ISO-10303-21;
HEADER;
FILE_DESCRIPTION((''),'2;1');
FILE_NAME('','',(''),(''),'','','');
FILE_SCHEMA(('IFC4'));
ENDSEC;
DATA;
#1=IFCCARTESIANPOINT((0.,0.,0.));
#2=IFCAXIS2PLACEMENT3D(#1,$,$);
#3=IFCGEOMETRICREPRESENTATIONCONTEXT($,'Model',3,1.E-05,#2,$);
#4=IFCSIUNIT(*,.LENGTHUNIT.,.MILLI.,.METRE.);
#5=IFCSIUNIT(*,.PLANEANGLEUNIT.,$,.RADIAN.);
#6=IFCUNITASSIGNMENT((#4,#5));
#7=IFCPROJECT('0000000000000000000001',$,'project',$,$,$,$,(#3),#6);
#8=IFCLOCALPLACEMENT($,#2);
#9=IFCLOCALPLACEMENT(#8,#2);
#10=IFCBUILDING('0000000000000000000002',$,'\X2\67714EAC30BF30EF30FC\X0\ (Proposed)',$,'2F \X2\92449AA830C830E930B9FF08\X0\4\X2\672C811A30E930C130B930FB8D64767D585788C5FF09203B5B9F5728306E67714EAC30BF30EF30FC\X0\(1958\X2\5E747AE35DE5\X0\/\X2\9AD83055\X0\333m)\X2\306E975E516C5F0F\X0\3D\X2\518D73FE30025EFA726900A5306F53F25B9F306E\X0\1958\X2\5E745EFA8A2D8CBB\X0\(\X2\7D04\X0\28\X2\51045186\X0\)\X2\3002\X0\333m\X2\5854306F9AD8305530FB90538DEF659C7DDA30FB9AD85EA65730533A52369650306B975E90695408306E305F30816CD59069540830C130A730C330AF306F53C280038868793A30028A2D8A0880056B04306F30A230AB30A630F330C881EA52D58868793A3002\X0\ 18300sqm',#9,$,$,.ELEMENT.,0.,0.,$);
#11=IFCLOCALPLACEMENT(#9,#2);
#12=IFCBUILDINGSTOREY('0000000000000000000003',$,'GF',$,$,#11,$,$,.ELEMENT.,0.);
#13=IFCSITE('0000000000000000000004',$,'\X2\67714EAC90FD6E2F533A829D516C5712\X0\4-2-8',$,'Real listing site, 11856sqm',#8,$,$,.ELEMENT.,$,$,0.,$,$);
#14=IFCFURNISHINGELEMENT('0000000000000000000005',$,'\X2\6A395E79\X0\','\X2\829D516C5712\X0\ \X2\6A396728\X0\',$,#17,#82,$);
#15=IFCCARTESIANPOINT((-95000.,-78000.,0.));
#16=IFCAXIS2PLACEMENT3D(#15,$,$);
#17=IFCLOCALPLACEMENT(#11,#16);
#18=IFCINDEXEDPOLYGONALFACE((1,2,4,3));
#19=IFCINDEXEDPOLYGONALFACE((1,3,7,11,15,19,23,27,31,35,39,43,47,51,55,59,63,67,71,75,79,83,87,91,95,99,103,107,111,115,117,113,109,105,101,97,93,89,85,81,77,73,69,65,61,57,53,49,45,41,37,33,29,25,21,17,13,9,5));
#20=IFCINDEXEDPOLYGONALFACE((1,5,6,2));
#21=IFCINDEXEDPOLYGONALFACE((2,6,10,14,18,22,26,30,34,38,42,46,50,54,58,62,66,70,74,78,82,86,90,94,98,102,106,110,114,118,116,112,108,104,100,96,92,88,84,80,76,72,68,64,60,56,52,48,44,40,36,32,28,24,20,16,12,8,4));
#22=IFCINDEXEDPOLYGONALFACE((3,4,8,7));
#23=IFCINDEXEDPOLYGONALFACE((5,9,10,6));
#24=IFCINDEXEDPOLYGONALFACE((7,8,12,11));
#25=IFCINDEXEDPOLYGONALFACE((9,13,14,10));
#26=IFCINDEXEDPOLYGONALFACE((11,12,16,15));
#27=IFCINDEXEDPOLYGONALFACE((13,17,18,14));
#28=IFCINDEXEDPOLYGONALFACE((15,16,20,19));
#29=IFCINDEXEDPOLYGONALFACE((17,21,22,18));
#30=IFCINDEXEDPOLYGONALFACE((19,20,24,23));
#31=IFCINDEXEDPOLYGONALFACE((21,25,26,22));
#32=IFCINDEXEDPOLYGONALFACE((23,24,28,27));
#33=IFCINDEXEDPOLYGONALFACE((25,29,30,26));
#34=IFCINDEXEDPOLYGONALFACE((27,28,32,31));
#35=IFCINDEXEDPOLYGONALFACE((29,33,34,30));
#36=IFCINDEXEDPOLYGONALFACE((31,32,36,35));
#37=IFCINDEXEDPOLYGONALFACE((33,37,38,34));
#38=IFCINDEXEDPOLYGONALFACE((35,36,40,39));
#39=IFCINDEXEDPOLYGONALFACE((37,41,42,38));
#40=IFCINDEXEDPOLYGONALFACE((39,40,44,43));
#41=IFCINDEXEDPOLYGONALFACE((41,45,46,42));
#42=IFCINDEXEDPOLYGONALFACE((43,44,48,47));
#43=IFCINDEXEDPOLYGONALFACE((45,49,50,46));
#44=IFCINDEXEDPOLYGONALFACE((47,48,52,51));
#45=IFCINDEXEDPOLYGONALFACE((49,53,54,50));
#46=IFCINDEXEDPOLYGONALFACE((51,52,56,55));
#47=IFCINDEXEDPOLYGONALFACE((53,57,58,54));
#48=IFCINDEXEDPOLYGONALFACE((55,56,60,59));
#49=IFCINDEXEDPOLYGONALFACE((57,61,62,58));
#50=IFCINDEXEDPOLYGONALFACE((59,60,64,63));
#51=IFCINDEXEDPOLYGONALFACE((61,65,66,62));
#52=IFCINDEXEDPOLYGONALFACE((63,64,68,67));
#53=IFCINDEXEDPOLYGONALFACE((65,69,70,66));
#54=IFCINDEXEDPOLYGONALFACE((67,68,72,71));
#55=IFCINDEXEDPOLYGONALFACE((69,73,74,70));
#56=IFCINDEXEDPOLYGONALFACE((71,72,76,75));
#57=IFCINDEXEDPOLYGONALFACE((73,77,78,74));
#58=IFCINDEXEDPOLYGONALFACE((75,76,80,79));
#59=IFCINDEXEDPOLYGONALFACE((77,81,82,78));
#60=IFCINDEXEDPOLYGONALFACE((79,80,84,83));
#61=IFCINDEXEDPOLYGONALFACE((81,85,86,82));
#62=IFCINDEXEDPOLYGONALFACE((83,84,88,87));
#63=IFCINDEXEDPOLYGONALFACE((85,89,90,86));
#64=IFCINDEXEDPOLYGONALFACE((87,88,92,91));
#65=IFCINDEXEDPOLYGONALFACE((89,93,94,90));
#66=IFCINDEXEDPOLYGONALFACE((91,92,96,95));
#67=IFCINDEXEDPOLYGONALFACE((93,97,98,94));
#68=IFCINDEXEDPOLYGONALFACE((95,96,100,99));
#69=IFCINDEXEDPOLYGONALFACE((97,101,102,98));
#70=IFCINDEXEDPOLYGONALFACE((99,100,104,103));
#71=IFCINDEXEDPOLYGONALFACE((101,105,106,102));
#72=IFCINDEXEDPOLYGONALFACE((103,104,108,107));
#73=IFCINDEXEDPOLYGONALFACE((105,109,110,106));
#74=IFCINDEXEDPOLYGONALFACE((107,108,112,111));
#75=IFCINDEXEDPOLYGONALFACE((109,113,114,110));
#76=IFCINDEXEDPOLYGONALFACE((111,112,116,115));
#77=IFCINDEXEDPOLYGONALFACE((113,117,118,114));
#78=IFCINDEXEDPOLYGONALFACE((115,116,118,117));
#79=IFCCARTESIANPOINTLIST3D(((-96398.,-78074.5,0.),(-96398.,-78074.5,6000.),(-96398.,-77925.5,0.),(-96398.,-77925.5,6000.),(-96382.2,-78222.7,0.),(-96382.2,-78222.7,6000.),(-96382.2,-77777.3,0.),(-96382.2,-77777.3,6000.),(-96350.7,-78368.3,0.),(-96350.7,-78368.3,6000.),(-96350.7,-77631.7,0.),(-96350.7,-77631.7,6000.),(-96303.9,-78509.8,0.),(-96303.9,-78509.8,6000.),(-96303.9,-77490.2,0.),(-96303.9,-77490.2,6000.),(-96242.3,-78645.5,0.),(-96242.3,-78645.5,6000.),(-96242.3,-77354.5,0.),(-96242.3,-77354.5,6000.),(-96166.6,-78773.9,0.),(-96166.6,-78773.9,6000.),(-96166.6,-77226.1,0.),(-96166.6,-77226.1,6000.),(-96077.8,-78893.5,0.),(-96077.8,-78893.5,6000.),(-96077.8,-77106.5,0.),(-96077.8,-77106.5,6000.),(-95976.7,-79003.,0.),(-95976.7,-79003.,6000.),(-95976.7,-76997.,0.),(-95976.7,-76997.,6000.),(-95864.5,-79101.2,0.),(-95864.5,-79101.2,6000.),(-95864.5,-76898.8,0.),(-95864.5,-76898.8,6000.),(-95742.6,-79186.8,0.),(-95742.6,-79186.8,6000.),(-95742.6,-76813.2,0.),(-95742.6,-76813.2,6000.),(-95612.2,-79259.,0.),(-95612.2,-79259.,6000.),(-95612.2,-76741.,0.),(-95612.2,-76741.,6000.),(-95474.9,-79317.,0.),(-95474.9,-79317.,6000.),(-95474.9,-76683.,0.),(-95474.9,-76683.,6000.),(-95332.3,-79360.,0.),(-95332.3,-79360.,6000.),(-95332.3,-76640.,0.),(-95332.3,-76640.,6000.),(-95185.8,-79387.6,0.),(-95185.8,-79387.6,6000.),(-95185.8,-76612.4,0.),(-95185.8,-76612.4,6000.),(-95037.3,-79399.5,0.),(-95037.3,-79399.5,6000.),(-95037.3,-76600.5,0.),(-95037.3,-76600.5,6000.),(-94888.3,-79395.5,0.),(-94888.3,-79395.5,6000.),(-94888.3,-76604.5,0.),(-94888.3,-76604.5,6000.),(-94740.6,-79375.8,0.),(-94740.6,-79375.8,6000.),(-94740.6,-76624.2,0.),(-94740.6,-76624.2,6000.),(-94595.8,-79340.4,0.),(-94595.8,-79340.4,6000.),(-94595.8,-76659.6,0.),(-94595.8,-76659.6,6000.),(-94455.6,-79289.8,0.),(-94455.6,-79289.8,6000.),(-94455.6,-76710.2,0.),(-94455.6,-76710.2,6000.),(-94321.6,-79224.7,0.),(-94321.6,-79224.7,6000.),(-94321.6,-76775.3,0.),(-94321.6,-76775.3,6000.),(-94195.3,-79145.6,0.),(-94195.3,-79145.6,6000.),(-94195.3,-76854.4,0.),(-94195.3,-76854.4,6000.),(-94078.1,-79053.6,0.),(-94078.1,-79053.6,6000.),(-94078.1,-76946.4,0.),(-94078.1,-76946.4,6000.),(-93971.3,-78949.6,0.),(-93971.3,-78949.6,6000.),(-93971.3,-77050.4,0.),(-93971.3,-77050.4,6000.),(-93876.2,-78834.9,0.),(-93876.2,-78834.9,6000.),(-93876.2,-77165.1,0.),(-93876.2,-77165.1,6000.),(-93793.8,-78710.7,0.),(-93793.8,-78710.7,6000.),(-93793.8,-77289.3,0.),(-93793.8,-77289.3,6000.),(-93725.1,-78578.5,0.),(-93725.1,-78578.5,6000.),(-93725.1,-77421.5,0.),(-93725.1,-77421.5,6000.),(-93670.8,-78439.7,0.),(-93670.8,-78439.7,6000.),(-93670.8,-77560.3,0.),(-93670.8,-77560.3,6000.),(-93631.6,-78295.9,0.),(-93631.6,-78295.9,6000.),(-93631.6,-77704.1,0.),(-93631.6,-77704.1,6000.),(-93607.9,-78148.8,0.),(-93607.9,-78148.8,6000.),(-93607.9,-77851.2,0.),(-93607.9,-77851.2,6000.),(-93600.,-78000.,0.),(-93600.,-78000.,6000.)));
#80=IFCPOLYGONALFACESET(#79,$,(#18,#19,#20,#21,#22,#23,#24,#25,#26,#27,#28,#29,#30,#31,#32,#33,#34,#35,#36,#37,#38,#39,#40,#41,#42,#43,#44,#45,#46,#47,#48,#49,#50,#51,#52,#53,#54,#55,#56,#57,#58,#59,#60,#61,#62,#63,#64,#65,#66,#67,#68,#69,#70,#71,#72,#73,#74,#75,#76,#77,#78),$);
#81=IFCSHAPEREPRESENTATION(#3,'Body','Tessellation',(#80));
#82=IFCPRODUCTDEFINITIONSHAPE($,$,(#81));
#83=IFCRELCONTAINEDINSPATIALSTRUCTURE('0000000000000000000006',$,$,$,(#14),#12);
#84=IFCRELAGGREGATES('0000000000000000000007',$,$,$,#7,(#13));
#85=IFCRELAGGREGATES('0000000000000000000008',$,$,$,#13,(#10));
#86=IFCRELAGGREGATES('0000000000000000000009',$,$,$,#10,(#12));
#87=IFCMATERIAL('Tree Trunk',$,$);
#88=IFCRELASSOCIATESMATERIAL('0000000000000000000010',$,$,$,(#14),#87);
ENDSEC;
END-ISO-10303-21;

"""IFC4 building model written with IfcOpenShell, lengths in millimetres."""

from ifc_helpers import new_model, si_unit, frame, origin, origin_2d, place, context, project, spatial, circle, extrude, material, element, save


model = new_model("IFC4")

# Units and contexts
model_context = context("Model", 3, precision=1e-05, world=origin())
ifc_project = project(units=[si_unit("LENGTHUNIT", "METRE", prefix="MILLI"), si_unit("PLANEANGLEUNIT", "RADIAN")], contexts=[model_context])

# Site, building, storey
site_placement = place(None, origin())
site = spatial("IfcSite", under=ifc_project, at=site_placement, Name="東京都港区芝公園4-2-8", ObjectType="Real listing site, 11856sqm", CompositionType="ELEMENT", RefElevation=0.0)
building_placement = place(site_placement, origin())
building = spatial("IfcBuilding", under=site, at=building_placement, Name="東京タワー (Proposed)", ObjectType="2F 鉄骨トラス（4本脚ラチス・赤白塗装）※実在の東京タワー(1958年竣工/高さ333m)の非公式3D再現。建物¥は史実の1958年建設費(約28億円)。333m塔は高さ・道路斜線・高度地区制限に非適合のため法適合チェックは参考表示。設計者欄はアカウント自動表示。 18300sqm", CompositionType="ELEMENT", ElevationOfRefHeight=0.0, ElevationOfTerrain=0.0)
storey_placement = place(building_placement, origin())
storey = spatial("IfcBuildingStorey", under=building, at=storey_placement, Name="GF", CompositionType="ELEMENT", Elevation=0.0)

# Furnishing element
ifc_material_1 = material(Name="Tree Trunk")
furnishing_1_placement = place(storey_placement, frame((-95000.0, -78000.0, 0.0)))
element("IfcFurnishingElement", 1, at=furnishing_1_placement, inside=storey, material=ifc_material_1, Name="樹幹", Description="芝公園 樹木", context=model_context, shape_type="SweptSolid", body=[
    extrude(circle(Radius=1400.0, at=origin_2d()), frame((-95000.0, -78000.0, 0.0)), (0.0, 0.0, 1.0), 6000.0),
])

save(model, "model.ifc")
